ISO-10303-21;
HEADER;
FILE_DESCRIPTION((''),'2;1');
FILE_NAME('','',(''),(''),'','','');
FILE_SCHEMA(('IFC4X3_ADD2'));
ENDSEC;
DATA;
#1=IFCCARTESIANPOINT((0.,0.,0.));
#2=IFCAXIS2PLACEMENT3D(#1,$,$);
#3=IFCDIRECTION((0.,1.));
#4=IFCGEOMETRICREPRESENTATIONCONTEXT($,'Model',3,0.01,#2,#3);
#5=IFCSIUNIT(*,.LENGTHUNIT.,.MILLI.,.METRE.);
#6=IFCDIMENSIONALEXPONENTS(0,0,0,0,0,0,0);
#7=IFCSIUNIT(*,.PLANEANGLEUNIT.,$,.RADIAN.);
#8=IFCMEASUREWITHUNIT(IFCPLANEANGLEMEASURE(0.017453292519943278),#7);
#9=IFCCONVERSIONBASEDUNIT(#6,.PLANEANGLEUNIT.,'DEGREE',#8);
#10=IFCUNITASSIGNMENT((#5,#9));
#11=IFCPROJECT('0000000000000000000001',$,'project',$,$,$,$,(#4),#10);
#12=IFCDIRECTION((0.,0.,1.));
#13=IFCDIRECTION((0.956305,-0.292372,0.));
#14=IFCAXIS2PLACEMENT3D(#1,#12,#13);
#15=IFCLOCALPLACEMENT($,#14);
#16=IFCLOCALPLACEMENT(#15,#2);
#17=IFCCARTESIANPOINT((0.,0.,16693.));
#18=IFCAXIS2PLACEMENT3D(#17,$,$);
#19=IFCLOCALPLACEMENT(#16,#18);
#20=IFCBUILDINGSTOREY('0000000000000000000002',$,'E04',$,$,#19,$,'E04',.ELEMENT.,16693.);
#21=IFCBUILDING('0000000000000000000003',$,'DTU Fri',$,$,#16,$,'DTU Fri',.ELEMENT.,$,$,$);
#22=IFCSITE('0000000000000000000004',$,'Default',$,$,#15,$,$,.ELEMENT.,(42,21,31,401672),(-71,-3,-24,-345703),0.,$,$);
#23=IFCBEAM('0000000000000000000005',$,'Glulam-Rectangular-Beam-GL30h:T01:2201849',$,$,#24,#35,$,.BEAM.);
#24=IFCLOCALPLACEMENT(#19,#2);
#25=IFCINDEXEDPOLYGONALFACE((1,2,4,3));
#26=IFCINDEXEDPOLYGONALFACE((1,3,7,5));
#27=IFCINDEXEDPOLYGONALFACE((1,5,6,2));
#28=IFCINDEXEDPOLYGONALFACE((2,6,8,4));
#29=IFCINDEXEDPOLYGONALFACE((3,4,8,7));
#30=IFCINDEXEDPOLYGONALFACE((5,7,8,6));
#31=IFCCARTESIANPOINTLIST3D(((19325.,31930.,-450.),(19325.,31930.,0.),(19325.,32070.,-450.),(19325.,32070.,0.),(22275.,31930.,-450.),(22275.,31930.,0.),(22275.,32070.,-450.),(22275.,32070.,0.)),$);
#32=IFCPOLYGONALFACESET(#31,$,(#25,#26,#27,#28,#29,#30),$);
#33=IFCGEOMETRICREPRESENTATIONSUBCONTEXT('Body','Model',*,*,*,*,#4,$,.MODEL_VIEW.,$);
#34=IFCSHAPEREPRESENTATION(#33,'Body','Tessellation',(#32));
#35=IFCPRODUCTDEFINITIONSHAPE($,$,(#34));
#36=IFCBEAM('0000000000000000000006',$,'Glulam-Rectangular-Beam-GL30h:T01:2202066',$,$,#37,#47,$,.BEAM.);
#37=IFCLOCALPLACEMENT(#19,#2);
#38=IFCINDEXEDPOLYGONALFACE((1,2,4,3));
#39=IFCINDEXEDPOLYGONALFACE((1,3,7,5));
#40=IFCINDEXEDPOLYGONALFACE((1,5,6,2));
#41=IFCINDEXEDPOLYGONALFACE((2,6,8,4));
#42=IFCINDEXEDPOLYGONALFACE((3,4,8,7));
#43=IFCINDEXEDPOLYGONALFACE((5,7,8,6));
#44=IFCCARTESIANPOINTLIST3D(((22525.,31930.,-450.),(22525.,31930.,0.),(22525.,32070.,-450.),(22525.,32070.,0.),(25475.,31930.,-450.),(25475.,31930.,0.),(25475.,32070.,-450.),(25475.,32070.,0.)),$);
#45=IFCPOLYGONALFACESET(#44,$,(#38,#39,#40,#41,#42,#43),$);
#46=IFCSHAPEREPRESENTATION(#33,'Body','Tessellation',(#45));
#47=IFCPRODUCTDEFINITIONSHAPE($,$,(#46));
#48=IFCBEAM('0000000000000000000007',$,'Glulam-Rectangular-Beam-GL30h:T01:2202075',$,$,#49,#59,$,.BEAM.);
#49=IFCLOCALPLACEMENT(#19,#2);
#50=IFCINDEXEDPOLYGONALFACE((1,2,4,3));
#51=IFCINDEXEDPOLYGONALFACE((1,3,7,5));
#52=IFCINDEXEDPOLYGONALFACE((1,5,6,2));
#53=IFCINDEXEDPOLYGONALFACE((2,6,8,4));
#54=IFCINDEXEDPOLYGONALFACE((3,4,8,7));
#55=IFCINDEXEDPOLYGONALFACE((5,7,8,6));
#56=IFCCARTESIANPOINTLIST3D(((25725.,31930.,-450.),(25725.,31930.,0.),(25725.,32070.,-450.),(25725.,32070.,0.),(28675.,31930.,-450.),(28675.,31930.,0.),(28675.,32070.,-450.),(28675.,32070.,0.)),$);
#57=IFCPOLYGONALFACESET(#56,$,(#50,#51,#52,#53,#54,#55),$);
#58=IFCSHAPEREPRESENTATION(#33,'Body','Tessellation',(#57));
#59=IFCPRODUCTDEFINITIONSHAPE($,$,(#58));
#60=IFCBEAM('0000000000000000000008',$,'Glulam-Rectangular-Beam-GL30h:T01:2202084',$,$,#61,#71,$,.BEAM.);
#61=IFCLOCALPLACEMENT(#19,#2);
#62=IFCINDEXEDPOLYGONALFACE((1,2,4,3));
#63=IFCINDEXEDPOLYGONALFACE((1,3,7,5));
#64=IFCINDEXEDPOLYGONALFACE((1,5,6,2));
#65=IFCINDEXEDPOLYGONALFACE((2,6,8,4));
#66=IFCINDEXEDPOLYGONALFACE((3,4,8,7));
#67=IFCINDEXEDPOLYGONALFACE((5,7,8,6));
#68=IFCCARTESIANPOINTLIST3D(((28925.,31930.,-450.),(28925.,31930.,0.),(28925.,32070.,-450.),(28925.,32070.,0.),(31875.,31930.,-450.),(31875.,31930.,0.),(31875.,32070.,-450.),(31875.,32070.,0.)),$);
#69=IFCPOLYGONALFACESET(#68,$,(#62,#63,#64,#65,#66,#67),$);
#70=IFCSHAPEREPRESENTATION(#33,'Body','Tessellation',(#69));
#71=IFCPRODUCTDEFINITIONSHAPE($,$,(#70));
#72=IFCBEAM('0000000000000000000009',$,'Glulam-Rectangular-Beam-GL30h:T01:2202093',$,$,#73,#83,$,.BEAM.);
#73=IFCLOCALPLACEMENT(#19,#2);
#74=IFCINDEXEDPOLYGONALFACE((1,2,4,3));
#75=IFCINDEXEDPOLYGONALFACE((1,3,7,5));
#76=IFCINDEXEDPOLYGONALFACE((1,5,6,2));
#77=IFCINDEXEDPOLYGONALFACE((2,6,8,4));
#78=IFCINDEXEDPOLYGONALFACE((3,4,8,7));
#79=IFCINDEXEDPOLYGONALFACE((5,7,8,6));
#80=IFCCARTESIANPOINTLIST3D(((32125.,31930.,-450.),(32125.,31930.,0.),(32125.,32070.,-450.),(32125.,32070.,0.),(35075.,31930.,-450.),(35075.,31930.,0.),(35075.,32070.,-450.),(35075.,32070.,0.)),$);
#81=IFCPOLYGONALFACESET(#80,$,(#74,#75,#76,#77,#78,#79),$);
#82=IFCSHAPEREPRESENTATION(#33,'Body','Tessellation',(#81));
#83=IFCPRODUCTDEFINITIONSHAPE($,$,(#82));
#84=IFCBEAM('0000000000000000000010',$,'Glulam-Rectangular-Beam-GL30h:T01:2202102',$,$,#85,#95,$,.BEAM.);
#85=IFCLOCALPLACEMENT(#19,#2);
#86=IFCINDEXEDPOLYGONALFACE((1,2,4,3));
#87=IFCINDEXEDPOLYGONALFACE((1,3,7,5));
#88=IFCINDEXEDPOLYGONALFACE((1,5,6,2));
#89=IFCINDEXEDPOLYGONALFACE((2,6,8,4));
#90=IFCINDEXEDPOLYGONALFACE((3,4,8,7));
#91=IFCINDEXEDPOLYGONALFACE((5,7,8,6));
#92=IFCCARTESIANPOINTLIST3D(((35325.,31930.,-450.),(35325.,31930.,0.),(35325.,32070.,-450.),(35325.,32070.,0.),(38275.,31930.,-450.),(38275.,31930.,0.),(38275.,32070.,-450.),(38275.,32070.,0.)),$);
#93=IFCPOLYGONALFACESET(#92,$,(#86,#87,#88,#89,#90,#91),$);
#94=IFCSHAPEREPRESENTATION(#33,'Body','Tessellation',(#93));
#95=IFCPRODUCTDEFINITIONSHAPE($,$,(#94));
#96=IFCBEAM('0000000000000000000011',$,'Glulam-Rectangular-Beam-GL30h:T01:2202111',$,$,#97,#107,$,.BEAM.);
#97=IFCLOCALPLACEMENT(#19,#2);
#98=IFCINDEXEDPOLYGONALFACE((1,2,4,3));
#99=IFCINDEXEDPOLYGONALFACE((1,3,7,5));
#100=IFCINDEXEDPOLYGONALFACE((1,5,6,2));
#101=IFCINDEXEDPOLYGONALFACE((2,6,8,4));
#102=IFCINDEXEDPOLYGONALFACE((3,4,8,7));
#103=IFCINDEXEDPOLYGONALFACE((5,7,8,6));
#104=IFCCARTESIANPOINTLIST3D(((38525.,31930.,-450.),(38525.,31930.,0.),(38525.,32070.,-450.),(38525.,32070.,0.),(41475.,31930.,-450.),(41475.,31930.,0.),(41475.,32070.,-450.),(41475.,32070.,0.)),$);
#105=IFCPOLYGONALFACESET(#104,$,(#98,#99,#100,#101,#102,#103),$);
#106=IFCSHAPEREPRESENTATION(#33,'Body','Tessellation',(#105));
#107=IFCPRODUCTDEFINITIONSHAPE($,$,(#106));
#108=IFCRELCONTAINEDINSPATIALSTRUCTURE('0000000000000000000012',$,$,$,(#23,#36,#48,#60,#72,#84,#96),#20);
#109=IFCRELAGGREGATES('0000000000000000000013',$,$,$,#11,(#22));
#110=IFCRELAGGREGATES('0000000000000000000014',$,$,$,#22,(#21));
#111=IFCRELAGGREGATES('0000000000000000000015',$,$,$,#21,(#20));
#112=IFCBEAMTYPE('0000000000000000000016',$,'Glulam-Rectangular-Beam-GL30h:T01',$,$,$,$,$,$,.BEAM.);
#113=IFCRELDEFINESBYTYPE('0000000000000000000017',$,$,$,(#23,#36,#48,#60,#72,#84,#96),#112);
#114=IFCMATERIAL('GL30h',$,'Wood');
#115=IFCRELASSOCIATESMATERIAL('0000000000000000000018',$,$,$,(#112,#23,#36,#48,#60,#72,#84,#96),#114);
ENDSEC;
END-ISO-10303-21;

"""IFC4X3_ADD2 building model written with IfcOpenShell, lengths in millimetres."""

from ifc_helpers import new_model, entity, si_unit, converted_unit, direction, frame, origin, origin_2d_with_axis, place, context, subcontext, project, spatial, rectangle, extrude, source, transform, mapped, material, material_profile, profile_set, profile_usage, type_object, type_shapes, element, save


model = new_model("IFC4X3_ADD2")

# Units and contexts
model_context = context("Model", 3, precision=0.01, world=origin(), true_north=direction((0.0, 1.0)))
body_context = subcontext(model_context, "Body", "Model", "MODEL_VIEW")
ifc_project = project(units=[si_unit("LENGTHUNIT", "METRE", prefix="MILLI"), converted_unit("PLANEANGLEUNIT", "DEGREE", entity("IfcPlaneAngleMeasure", 0.017453292519943278), si_unit("PLANEANGLEUNIT", "RADIAN"), dimensions=[0, 0, 0, 0, 0, 0, 0])], contexts=[model_context])

# Site, building, storey
site_placement = place(None, frame((0.0, 0.0, 0.0), z_axis=(0.0, 0.0, 1.0), x_axis=(0.956305, -0.292372, 0.0)))
site = spatial("IfcSite", under=ifc_project, at=site_placement, Name="Default", CompositionType="ELEMENT", RefLatitude=(42, 21, 31, 401672), RefLongitude=(-71, -3, -24, -345703), RefElevation=0.0)
building_placement = place(site_placement, origin())
building = spatial("IfcBuilding", under=site, at=building_placement, Name="DTU Fri", LongName="DTU Fri", CompositionType="ELEMENT")
storey_placement = place(building_placement, frame((0.0, 0.0, 16693.0)))
storey = spatial("IfcBuildingStorey", under=building, at=storey_placement, Name="E04", LongName="E04", CompositionType="ELEMENT", Elevation=16693.0)

# Beams
ifc_material = material(Name="GL30h", Category="Wood")
ifc_material_profile_1 = material_profile(ifc_material, rectangle(XDim=450.0, YDim=140.0, at=origin_2d_with_axis()), Name="T01")
ifc_profile_set_1 = profile_set([ifc_material_profile_1], Name="T01")
ifc_profile_usage_1 = profile_usage(ifc_profile_set_1, cardinal=8)
beam_type_1 = type_object("IfcBeamType", Name="Glulam-Rectangular-Beam-GL30h:T01", PredefinedType="BEAM", material=ifc_profile_set_1)
shared_shape_1 = source(origin(), body_context, "Body", "SweptSolid", [
    extrude(rectangle(XDim=450.0, YDim=140.0, at=origin_2d_with_axis()), frame((-1475.0, 0.0, 0.0), z_axis=(1.0, 0.0, 0.0), x_axis=(0.0, 0.0, -1.0)), (0.0, 0.0, 1.0), 2950.0),
])
type_shapes(beam_type_1, [shared_shape_1])
for number, where, z_axis, x_axis, name in (
    (1, (20800.0, 32000.0, -225.0), (0.0, 0.0, 1.0), (-1.0, 0.0, 0.0), "Glulam-Rectangular-Beam-GL30h:T01:2201849"),
    (2, (24000.0, 32000.0, -225.0), (0.0, 0.0, 1.0), (-1.0, 0.0, 0.0), "Glulam-Rectangular-Beam-GL30h:T01:2202066"),
    (3, (27200.0, 32000.0, -225.0), (0.0, 0.0, 1.0), (-1.0, 0.0, 0.0), "Glulam-Rectangular-Beam-GL30h:T01:2202075"),
    (4, (30400.0, 32000.0, -225.0), (0.0, 0.0, 1.0), (-1.0, 0.0, 0.0), "Glulam-Rectangular-Beam-GL30h:T01:2202084"),
    (5, (33600.0, 32000.0, -225.0), (0.0, 0.0, 1.0), (-1.0, 0.0, 0.0), "Glulam-Rectangular-Beam-GL30h:T01:2202093"),
    (6, (36800.0, 32000.0, -225.0), (0.0, 0.0, 1.0), (-1.0, 0.0, 0.0), "Glulam-Rectangular-Beam-GL30h:T01:2202102"),
    (7, (40000.0, 32000.0, -225.0), (0.0, 0.0, 1.0), (-1.0, 0.0, 0.0), "Glulam-Rectangular-Beam-GL30h:T01:2202111"),
):
    element("IfcBeam", number, at=place(storey_placement, frame(where, z_axis=z_axis, x_axis=x_axis)), inside=storey, type_object=beam_type_1, material=ifc_profile_usage_1, Name=name, PredefinedType="BEAM", context=body_context, shape_type="MappedRepresentation", body=[
        mapped(shared_shape_1, transform((0.0, 0.0, 0.0), scale=1.0)),
    ])

save(model, "model.ifc")
